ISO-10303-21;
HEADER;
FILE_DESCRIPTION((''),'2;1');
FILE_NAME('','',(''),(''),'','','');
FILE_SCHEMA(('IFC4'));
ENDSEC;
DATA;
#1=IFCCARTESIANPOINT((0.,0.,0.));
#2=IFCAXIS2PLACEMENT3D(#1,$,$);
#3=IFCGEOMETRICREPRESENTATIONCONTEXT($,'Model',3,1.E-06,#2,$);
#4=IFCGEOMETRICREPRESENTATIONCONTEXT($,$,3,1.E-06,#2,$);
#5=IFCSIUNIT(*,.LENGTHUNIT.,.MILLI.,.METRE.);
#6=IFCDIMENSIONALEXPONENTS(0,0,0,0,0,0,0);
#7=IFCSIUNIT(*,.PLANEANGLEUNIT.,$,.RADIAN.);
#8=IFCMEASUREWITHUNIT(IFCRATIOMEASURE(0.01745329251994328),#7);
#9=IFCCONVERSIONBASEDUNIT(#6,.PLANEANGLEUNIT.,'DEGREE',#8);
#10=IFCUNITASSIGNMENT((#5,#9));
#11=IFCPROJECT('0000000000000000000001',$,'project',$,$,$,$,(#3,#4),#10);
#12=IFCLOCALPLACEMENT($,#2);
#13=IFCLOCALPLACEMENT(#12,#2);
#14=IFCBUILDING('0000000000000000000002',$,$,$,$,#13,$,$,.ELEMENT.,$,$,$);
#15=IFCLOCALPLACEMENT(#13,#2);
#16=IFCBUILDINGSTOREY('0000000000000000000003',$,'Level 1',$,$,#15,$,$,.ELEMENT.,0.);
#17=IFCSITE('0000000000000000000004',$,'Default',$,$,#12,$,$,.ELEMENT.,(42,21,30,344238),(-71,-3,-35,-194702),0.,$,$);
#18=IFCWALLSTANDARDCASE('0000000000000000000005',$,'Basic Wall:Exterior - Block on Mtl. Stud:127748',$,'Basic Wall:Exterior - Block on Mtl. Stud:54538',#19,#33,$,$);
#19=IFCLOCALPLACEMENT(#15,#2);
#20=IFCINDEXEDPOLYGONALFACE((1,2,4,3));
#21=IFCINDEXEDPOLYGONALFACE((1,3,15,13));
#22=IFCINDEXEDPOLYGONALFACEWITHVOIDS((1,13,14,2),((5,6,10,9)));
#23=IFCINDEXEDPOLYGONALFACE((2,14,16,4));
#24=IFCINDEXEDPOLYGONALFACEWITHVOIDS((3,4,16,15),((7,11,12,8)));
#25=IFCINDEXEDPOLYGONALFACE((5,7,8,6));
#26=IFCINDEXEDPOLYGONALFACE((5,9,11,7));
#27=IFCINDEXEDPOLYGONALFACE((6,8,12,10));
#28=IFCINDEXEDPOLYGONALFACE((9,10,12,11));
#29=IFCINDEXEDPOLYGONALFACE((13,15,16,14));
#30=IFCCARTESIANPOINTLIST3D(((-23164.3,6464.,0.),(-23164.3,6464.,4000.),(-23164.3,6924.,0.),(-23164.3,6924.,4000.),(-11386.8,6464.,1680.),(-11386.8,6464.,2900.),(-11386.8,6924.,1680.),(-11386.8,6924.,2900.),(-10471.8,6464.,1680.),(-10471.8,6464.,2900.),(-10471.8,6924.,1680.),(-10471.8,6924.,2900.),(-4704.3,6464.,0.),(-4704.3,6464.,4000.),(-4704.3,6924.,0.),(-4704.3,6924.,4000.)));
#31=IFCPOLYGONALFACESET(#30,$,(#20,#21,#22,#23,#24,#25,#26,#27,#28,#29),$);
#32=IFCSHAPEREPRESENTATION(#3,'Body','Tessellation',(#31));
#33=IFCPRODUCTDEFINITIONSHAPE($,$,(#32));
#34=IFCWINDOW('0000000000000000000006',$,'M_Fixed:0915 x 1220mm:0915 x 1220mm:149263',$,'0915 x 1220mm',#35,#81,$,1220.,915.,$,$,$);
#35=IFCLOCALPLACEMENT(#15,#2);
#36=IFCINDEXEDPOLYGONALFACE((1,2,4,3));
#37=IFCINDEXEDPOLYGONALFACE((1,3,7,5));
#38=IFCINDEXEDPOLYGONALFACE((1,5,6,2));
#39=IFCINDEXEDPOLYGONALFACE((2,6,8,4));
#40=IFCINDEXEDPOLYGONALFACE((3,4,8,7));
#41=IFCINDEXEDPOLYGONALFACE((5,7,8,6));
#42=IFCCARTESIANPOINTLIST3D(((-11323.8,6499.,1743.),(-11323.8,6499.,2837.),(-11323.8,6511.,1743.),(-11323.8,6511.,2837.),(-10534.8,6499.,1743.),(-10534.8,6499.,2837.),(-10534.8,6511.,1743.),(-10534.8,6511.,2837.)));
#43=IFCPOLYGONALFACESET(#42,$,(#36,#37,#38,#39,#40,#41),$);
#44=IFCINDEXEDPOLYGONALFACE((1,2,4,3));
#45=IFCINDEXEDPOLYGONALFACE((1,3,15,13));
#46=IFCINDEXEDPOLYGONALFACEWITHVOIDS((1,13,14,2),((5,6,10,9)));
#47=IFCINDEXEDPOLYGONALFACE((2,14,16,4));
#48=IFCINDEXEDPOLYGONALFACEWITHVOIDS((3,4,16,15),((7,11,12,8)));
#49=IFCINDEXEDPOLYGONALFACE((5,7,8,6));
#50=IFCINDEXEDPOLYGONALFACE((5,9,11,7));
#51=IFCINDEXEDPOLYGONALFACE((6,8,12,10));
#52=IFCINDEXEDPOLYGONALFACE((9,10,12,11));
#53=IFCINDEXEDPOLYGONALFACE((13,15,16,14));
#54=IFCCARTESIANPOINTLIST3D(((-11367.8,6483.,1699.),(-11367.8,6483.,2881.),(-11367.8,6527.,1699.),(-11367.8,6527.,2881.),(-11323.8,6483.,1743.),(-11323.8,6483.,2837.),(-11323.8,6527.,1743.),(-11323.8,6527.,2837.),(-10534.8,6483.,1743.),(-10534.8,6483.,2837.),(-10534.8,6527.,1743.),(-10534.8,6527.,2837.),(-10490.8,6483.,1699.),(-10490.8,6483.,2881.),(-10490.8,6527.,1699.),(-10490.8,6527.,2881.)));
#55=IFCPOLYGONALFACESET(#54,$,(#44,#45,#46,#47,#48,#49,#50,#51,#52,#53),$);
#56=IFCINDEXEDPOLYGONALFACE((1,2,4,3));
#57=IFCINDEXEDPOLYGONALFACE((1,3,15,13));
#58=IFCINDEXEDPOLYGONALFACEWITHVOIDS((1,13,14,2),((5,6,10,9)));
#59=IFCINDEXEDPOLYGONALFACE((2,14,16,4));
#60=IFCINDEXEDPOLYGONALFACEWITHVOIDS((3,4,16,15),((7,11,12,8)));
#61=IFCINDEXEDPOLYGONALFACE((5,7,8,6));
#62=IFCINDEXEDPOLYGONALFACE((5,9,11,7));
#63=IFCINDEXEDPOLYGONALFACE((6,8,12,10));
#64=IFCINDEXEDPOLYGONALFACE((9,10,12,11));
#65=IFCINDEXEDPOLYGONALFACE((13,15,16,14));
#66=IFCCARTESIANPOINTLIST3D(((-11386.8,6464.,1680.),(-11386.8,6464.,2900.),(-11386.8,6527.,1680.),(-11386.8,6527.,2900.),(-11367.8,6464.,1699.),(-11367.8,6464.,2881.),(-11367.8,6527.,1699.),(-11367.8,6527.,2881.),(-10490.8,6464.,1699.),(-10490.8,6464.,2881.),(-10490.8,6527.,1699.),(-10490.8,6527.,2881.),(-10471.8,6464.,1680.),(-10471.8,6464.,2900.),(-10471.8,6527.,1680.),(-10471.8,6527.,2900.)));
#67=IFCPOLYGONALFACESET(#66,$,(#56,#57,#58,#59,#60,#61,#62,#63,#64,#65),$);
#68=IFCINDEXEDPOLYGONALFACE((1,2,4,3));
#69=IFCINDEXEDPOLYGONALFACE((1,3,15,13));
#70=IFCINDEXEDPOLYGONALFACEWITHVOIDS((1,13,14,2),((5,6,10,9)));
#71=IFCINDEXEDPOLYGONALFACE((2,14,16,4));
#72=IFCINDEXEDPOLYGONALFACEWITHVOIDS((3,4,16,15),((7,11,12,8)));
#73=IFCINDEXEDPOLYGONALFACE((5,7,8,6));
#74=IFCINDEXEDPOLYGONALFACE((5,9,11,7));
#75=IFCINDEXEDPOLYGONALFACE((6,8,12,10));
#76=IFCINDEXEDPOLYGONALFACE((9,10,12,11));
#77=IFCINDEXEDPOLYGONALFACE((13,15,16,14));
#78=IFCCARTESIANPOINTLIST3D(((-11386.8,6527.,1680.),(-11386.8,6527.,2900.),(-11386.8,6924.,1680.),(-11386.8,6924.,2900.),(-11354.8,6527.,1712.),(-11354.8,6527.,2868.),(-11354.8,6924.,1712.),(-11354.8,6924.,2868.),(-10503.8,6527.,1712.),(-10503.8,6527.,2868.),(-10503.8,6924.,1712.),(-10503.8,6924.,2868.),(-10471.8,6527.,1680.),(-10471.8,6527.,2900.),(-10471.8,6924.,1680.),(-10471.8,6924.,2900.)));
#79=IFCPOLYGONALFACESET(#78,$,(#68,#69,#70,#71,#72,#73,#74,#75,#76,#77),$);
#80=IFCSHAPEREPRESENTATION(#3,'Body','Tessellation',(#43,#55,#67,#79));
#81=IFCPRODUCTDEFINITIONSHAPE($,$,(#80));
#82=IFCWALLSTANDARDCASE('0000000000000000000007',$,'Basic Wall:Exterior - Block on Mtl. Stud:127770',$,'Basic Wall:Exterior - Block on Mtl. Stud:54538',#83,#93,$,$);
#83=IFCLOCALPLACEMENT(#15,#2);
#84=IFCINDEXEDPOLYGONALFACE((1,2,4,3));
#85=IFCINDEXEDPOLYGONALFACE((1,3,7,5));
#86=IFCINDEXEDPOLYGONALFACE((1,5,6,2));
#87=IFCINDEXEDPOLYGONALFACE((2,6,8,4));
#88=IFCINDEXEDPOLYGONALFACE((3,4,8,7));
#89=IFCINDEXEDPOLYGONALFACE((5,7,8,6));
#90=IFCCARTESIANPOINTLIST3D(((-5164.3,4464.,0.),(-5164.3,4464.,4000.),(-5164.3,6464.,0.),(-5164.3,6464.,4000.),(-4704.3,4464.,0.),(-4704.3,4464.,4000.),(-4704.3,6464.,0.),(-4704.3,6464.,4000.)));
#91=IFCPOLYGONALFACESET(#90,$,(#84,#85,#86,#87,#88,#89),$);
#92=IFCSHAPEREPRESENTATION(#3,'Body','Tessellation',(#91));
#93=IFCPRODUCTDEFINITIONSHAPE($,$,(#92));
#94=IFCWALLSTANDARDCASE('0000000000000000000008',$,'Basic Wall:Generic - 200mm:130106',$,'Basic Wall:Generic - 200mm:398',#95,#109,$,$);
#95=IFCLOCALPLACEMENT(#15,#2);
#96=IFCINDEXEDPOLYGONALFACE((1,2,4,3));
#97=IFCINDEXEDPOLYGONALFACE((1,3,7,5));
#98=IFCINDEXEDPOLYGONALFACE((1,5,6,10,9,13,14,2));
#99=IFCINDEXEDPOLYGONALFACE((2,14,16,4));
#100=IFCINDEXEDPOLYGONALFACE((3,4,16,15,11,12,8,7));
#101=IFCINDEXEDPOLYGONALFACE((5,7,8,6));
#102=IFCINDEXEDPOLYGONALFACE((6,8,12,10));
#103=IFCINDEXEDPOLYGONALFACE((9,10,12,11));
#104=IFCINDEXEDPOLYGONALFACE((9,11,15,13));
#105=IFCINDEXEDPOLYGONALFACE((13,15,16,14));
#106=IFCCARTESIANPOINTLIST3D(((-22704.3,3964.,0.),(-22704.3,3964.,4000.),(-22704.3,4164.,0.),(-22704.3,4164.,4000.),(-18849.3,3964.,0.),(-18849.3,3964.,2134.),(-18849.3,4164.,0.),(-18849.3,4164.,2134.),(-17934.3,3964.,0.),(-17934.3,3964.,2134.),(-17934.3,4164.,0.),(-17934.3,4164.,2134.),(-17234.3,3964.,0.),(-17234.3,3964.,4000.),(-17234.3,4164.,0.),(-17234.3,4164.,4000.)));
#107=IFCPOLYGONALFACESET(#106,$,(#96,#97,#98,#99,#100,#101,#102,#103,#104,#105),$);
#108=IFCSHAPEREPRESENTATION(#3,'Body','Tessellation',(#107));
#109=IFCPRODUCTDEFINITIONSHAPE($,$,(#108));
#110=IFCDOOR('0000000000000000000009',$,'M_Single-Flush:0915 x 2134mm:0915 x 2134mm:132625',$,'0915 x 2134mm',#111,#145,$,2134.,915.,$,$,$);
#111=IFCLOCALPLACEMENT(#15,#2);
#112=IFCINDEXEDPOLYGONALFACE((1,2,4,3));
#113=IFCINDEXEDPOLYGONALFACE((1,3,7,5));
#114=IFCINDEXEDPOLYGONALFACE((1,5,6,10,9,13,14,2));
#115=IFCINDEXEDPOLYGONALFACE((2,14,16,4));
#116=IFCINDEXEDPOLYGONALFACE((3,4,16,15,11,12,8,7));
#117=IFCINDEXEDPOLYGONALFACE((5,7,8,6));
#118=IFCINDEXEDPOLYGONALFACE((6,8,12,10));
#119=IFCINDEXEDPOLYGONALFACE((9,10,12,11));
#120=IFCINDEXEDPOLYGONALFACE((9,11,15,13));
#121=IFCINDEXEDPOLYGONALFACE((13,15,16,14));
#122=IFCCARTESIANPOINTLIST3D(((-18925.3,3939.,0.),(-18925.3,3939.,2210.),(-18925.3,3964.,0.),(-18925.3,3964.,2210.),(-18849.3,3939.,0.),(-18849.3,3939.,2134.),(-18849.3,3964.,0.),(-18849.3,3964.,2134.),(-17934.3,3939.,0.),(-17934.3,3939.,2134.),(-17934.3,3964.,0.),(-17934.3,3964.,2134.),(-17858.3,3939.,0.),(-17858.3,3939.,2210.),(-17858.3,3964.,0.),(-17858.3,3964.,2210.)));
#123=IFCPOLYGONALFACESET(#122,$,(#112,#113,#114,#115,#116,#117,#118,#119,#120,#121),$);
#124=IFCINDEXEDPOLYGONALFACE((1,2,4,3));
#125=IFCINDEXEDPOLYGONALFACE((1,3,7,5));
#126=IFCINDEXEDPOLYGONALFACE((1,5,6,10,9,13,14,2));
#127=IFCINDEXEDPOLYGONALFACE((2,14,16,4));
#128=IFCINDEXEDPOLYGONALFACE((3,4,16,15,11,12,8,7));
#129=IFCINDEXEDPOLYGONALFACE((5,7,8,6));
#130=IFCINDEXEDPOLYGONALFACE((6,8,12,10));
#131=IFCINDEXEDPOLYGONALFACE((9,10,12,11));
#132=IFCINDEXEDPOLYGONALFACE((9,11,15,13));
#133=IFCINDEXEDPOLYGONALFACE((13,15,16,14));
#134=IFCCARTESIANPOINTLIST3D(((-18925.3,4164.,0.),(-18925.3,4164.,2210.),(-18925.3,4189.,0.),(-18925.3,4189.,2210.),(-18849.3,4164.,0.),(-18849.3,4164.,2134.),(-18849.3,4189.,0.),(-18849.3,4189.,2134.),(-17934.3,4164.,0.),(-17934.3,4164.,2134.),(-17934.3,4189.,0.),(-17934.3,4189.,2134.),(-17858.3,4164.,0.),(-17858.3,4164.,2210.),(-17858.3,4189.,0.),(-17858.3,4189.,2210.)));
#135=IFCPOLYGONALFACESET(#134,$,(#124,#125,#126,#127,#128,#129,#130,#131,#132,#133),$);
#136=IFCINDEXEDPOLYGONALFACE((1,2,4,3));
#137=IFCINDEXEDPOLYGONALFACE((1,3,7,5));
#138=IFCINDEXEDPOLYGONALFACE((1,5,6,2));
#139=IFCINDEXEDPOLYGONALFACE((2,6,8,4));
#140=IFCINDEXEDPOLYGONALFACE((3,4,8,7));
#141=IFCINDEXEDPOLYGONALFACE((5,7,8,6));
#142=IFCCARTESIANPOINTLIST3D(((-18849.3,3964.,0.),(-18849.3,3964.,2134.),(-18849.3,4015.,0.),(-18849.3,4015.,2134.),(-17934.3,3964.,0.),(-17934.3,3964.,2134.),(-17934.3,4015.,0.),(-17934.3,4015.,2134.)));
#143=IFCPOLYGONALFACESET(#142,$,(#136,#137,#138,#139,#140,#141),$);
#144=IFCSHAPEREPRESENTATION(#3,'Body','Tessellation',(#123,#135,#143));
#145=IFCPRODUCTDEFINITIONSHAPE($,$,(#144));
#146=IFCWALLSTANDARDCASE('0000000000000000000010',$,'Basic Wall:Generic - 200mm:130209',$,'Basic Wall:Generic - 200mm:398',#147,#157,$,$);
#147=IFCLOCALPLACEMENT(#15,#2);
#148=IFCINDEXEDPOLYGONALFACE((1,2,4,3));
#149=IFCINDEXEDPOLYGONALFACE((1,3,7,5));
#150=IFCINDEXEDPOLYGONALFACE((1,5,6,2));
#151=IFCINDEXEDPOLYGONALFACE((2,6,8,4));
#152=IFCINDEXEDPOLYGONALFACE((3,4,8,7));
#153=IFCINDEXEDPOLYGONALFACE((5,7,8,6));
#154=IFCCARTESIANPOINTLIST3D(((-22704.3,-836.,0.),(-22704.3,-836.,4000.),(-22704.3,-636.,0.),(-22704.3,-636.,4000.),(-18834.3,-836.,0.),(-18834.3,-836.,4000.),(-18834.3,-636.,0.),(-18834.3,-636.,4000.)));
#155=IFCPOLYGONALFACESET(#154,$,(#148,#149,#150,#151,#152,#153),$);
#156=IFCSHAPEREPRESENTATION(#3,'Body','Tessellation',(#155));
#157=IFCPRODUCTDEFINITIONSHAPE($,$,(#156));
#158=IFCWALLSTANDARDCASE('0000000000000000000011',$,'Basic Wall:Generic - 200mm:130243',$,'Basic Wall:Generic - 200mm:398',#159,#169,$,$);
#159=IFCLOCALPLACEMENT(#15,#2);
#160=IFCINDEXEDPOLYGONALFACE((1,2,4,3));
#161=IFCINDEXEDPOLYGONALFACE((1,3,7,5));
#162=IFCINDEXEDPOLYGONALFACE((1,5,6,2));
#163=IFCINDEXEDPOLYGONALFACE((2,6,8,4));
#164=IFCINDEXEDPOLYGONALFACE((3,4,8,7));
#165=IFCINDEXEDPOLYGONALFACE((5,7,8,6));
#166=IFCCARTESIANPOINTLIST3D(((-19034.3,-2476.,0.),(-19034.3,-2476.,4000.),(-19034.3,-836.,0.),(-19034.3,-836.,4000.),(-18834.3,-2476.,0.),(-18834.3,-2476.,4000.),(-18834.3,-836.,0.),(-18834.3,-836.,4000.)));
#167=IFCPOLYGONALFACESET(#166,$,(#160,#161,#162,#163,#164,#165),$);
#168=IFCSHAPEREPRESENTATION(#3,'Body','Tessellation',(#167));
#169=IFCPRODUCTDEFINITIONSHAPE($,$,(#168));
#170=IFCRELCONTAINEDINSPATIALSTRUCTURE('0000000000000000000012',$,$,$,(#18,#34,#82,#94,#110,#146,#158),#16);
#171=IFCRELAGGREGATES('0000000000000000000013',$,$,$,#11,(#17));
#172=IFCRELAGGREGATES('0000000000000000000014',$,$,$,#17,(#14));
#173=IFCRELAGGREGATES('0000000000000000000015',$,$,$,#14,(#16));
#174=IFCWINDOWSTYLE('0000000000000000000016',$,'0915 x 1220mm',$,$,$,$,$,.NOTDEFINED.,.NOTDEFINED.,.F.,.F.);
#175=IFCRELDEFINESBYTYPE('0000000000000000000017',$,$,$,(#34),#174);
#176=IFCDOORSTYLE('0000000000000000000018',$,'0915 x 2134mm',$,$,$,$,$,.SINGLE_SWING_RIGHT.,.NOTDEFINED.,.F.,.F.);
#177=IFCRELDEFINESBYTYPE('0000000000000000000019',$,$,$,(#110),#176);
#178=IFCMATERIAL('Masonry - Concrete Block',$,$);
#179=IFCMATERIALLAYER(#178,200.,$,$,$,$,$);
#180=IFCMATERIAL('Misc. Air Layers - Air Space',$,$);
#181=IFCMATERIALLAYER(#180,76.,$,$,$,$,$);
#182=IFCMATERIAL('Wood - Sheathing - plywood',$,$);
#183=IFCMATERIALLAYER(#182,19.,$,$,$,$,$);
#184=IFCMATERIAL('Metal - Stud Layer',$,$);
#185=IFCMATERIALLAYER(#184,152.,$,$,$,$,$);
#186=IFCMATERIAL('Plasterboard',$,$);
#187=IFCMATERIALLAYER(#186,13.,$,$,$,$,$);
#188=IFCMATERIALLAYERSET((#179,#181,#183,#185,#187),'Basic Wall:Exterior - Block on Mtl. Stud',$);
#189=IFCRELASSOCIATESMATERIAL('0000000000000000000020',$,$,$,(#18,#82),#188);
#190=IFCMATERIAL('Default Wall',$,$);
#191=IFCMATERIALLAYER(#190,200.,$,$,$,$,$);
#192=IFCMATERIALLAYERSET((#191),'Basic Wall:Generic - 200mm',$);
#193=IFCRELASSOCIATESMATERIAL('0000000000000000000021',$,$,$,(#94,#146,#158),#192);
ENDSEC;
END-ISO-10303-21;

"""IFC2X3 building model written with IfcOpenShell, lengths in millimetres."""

from ifc_helpers import new_model, entity, si_unit, converted_unit, frame, frame_2d, origin, origin_2d_with_axis, place, context, project, spatial, polyline, rectangle, outline, extrude, source, transform, mapped, material, layer, layer_set, layer_usage, type_object, type_shapes, element, fill, save


model = new_model("IFC2X3")

# Units and contexts
model_context = context("Model", 3, precision=1e-06, world=origin())
context_of_model = context(None, 3, precision=1e-06, world=origin())
ifc_project = project(units=[si_unit("LENGTHUNIT", "METRE", prefix="MILLI"), converted_unit("PLANEANGLEUNIT", "DEGREE", entity("IfcRatioMeasure", 0.01745329251994328), si_unit("PLANEANGLEUNIT", "RADIAN"), dimensions=[0, 0, 0, 0, 0, 0, 0])], contexts=[model_context, context_of_model])

# Site, building, storey
site_placement = place(None, origin())
site = spatial("IfcSite", under=ifc_project, at=site_placement, Name="Default", CompositionType="ELEMENT", RefLatitude=(42, 21, 30, 344238), RefLongitude=(-71, -3, -35, -194702), RefElevation=0.0)
building_placement = place(site_placement, origin())
building = spatial("IfcBuilding", under=site, at=building_placement, CompositionType="ELEMENT")
storey_placement = place(building_placement, origin())
storey = spatial("IfcBuildingStorey", under=building, at=storey_placement, Name="Level 1", CompositionType="ELEMENT", Elevation=0.0)

# Wall, opening, window
ifc_material_1 = material(Name="Masonry - Concrete Block")
ifc_layer_1 = layer(ifc_material_1, 200.0)
ifc_material_2 = material(Name="Misc. Air Layers - Air Space")
ifc_layer_2 = layer(ifc_material_2, 76.0)
ifc_material_3 = material(Name="Wood - Sheathing - plywood")
ifc_layer_3 = layer(ifc_material_3, 19.0)
ifc_material_4 = material(Name="Metal - Stud Layer")
ifc_layer_4 = layer(ifc_material_4, 152.0)
ifc_material_5 = material(Name="Plasterboard")
ifc_layer_5 = layer(ifc_material_5, 13.0)
ifc_layer_set_1 = layer_set([ifc_layer_1, ifc_layer_2, ifc_layer_3, ifc_layer_4, ifc_layer_5], Name="Basic Wall:Exterior - Block on Mtl. Stud")
ifc_layer_usage_1 = layer_usage(ifc_layer_set_1, "AXIS2", "NEGATIVE", 230.0)
wall_1_placement = place(storey_placement, frame((-23164.3, 6694.0, 0.0)))
wall_1 = element("IfcWallStandardCase", 1, at=wall_1_placement, inside=storey, material=ifc_layer_usage_1, Name="Basic Wall:Exterior - Block on Mtl. Stud:127748", ObjectType="Basic Wall:Exterior - Block on Mtl. Stud:54538", context=model_context, shape_type="SweptSolid", body=[
    extrude(rectangle(XDim=18460.0, YDim=460.0, at=frame_2d((9230.0, 0.0), x_axis=(-1.0, 0.0))), origin(), (0.0, 0.0, 1.0), 4000.0),
])
opening_1_placement = place(wall_1_placement, frame((11777.5, -230.0, 1680.0)))
opening_1 = element("IfcOpeningElement", 2, at=opening_1_placement, cuts=wall_1, ObjectType="Opening", context=model_context, shape_type="SweptSolid", body=[
    extrude(rectangle(XDim=1220.0, YDim=915.0, at=frame_2d((610.0, 457.5), x_axis=(1.0, 0.0))), frame((0.0, 0.0, 0.0), z_axis=(0.0, 1.0, 0.0), x_axis=(0.0, 0.0, 1.0)), (0.0, 0.0, 1.0), 460.0),
])
window_style = type_object("IfcWindowStyle", Name="0915 x 1220mm", ConstructionType="NOTDEFINED", OperationType="NOTDEFINED", ParameterTakesPrecedence=False, Sizeable=False)
shared_shape_1 = source(origin(), model_context, "Body", "SweptSolid", [
    extrude(rectangle(XDim=12.0, YDim=789.0, at=origin_2d_with_axis()), frame((457.5, 419.0, 63.0), z_axis=(0.0, 0.0, 1.0), x_axis=(0.0, -1.0, 0.0)), (0.0, 0.0, 1.0), 1094.0),
    extrude(outline(polyline([(-438.5, -591.0), (438.5, -591.0), (438.5, 591.0), (-438.5, 591.0), (-438.5, -591.0)]), holes=[polyline([(-394.5, -547.0), (-394.5, 547.0), (394.5, 547.0), (394.5, -547.0), (-394.5, -547.0)])]), frame((457.5, 397.0, 610.0), z_axis=(0.0, 1.0, 0.0), x_axis=(1.0, 0.0, 0.0)), (0.0, 0.0, 1.0), 44.0),
    extrude(outline(polyline([(-457.5, -610.0), (457.5, -610.0), (457.5, 610.0), (-457.5, 610.0), (-457.5, -610.0)]), holes=[polyline([(-438.5, -591.0), (-438.5, 591.0), (438.5, 591.0), (438.5, -591.0), (-438.5, -591.0)])]), frame((457.5, 397.0, 610.0), z_axis=(0.0, 1.0, 0.0), x_axis=(1.0, 0.0, 0.0)), (0.0, 0.0, 1.0), 63.0),
    extrude(outline(polyline([(-457.5, -610.0), (457.5, -610.0), (457.5, 610.0), (-457.5, 610.0), (-457.5, -610.0)]), holes=[polyline([(-425.5, -578.0), (-425.5, 578.0), (425.5, 578.0), (425.5, -578.0), (-425.5, -578.0)])]), frame((457.5, 0.0, 610.0), z_axis=(0.0, 1.0, 0.0), x_axis=(1.0, 0.0, 0.0)), (0.0, 0.0, 1.0), 397.0),
])
type_shapes(window_style, [shared_shape_1])
window_placement = place(opening_1_placement, frame((915.0, 460.0, 0.0), z_axis=(0.0, 0.0, 1.0), x_axis=(-1.0, 0.0, 0.0)))
window = element("IfcWindow", 3, at=window_placement, inside=storey, type_object=window_style, Name="M_Fixed:0915 x 1220mm:0915 x 1220mm:149263", ObjectType="0915 x 1220mm", OverallHeight=1220.0, OverallWidth=915.0, context=model_context, shape_type="MappedRepresentation", body=[
    mapped(shared_shape_1, transform((0.0, 0.0, 0.0), scale=1.0)),
])
fill(opening_1, window)

# Wall
ifc_layer_usage_2 = layer_usage(ifc_layer_set_1, "AXIS2", "NEGATIVE", 230.0)
wall_2_placement = place(storey_placement, frame((-4934.3, 6464.0, 0.0), z_axis=(0.0, 0.0, 1.0), x_axis=(0.0, -1.0, 0.0)))
element("IfcWallStandardCase", 4, at=wall_2_placement, inside=storey, material=ifc_layer_usage_2, Name="Basic Wall:Exterior - Block on Mtl. Stud:127770", ObjectType="Basic Wall:Exterior - Block on Mtl. Stud:54538", context=model_context, shape_type="SweptSolid", body=[
    extrude(rectangle(XDim=2000.0, YDim=460.0, at=frame_2d((1000.0, 0.0), x_axis=(-1.0, 0.0))), origin(), (0.0, 0.0, 1.0), 4000.0),
])

# Wall, opening, door
ifc_material_6 = material(Name="Default Wall")
ifc_layer_6 = layer(ifc_material_6, 200.0)
ifc_layer_set_2 = layer_set([ifc_layer_6], Name="Basic Wall:Generic - 200mm")
ifc_layer_usage_3 = layer_usage(ifc_layer_set_2, "AXIS2", "NEGATIVE", 100.0)
wall_3_placement = place(storey_placement, frame((-22704.3, 4064.0, 0.0)))
wall_3 = element("IfcWallStandardCase", 5, at=wall_3_placement, inside=storey, material=ifc_layer_usage_3, Name="Basic Wall:Generic - 200mm:130106", ObjectType="Basic Wall:Generic - 200mm:398", context=model_context, shape_type="SweptSolid", body=[
    extrude(rectangle(XDim=5470.0, YDim=200.0, at=frame_2d((2735.0, 0.0), x_axis=(-1.0, 0.0))), origin(), (0.0, 0.0, 1.0), 4000.0),
])
opening_2_placement = place(wall_3_placement, frame((4770.0, 100.0, 0.0)))
opening_2 = element("IfcOpeningElement", 6, at=opening_2_placement, cuts=wall_3, ObjectType="Opening", context=model_context, shape_type="SweptSolid", body=[
    extrude(rectangle(XDim=915.0, YDim=2134.0, at=frame_2d((1067.0, 457.5), x_axis=(0.0, 1.0))), frame((0.0, 0.0, 0.0), z_axis=(0.0, -1.0, 0.0), x_axis=(0.0, 0.0, 1.0)), (0.0, 0.0, 1.0), 200.0),
])
door_style = type_object("IfcDoorStyle", Name="0915 x 2134mm", ConstructionType="NOTDEFINED", OperationType="SINGLE_SWING_RIGHT", ParameterTakesPrecedence=False, Sizeable=False)
shared_shape_2 = source(origin(), model_context, "Body", "SweptSolid", [
    extrude(outline(polyline([(-533.5, -1124.0), (533.5, -1124.0), (533.5, 1086.0), (457.5, 1086.0), (457.5, -1048.0), (-457.5, -1048.0), (-457.5, 1086.0), (-533.5, 1086.0), (-533.5, -1124.0)])), frame((457.5, 200.0, 1086.0), z_axis=(0.0, 1.0, 0.0), x_axis=(1.0, 0.0, 0.0)), (0.0, 0.0, 1.0), 25.0),
    extrude(outline(polyline([(-1124.0, -533.5), (1086.0, -533.5), (1086.0, -457.5), (-1048.0, -457.5), (-1048.0, 457.5), (1086.0, 457.5), (1086.0, 533.5), (-1124.0, 533.5), (-1124.0, -533.5)])), frame((457.5, -25.0, 1086.0), z_axis=(0.0, 1.0, 0.0), x_axis=(0.0, 0.0, -1.0)), (0.0, 0.0, 1.0), 25.0),
    extrude(rectangle(XDim=51.0, YDim=915.0, at=origin_2d_with_axis()), frame((457.5, 174.5, 0.0), z_axis=(0.0, 0.0, 1.0), x_axis=(0.0, 1.0, 0.0)), (0.0, 0.0, 1.0), 2134.0),
])
type_shapes(door_style, [shared_shape_2])
door_1_placement = place(opening_2_placement, frame((0.0, 0.0, 0.0), z_axis=(0.0, 0.0, 1.0), x_axis=(-1.0, 0.0, 0.0)))
door_1 = element("IfcDoor", 7, at=door_1_placement, inside=storey, type_object=door_style, Name="M_Single-Flush:0915 x 2134mm:0915 x 2134mm:132625", ObjectType="0915 x 2134mm", OverallHeight=2134.0, OverallWidth=915.0, context=model_context, shape_type="MappedRepresentation", body=[
    mapped(shared_shape_2, transform((0.0, 0.0, 0.0), scale=1.0)),
])
fill(opening_2, door_1)

# Walls
ifc_layer_usage_4 = layer_usage(ifc_layer_set_2, "AXIS2", "NEGATIVE", 100.0)
wall_4_placement = place(storey_placement, frame((-22704.3, -736.0, 0.0)))
element("IfcWallStandardCase", 8, at=wall_4_placement, inside=storey, material=ifc_layer_usage_4, Name="Basic Wall:Generic - 200mm:130209", ObjectType="Basic Wall:Generic - 200mm:398", context=model_context, shape_type="SweptSolid", body=[
    extrude(rectangle(XDim=3870.0, YDim=200.0, at=frame_2d((1935.0, 0.0), x_axis=(-1.0, 0.0))), origin(), (0.0, 0.0, 1.0), 4000.0),
])
ifc_layer_usage_5 = layer_usage(ifc_layer_set_2, "AXIS2", "NEGATIVE", 100.0)
wall_5_placement = place(storey_placement, frame((-18934.3, -836.0, 0.0), z_axis=(0.0, 0.0, 1.0), x_axis=(0.0, -1.0, 0.0)))
element("IfcWallStandardCase", 9, at=wall_5_placement, inside=storey, material=ifc_layer_usage_5, Name="Basic Wall:Generic - 200mm:130243", ObjectType="Basic Wall:Generic - 200mm:398", context=model_context, shape_type="SweptSolid", body=[
    extrude(rectangle(XDim=1640.0, YDim=200.0, at=frame_2d((820.0, 0.0), x_axis=(-1.0, 0.0))), origin(), (0.0, 0.0, 1.0), 4000.0),
])

save(model, "model.ifc")
